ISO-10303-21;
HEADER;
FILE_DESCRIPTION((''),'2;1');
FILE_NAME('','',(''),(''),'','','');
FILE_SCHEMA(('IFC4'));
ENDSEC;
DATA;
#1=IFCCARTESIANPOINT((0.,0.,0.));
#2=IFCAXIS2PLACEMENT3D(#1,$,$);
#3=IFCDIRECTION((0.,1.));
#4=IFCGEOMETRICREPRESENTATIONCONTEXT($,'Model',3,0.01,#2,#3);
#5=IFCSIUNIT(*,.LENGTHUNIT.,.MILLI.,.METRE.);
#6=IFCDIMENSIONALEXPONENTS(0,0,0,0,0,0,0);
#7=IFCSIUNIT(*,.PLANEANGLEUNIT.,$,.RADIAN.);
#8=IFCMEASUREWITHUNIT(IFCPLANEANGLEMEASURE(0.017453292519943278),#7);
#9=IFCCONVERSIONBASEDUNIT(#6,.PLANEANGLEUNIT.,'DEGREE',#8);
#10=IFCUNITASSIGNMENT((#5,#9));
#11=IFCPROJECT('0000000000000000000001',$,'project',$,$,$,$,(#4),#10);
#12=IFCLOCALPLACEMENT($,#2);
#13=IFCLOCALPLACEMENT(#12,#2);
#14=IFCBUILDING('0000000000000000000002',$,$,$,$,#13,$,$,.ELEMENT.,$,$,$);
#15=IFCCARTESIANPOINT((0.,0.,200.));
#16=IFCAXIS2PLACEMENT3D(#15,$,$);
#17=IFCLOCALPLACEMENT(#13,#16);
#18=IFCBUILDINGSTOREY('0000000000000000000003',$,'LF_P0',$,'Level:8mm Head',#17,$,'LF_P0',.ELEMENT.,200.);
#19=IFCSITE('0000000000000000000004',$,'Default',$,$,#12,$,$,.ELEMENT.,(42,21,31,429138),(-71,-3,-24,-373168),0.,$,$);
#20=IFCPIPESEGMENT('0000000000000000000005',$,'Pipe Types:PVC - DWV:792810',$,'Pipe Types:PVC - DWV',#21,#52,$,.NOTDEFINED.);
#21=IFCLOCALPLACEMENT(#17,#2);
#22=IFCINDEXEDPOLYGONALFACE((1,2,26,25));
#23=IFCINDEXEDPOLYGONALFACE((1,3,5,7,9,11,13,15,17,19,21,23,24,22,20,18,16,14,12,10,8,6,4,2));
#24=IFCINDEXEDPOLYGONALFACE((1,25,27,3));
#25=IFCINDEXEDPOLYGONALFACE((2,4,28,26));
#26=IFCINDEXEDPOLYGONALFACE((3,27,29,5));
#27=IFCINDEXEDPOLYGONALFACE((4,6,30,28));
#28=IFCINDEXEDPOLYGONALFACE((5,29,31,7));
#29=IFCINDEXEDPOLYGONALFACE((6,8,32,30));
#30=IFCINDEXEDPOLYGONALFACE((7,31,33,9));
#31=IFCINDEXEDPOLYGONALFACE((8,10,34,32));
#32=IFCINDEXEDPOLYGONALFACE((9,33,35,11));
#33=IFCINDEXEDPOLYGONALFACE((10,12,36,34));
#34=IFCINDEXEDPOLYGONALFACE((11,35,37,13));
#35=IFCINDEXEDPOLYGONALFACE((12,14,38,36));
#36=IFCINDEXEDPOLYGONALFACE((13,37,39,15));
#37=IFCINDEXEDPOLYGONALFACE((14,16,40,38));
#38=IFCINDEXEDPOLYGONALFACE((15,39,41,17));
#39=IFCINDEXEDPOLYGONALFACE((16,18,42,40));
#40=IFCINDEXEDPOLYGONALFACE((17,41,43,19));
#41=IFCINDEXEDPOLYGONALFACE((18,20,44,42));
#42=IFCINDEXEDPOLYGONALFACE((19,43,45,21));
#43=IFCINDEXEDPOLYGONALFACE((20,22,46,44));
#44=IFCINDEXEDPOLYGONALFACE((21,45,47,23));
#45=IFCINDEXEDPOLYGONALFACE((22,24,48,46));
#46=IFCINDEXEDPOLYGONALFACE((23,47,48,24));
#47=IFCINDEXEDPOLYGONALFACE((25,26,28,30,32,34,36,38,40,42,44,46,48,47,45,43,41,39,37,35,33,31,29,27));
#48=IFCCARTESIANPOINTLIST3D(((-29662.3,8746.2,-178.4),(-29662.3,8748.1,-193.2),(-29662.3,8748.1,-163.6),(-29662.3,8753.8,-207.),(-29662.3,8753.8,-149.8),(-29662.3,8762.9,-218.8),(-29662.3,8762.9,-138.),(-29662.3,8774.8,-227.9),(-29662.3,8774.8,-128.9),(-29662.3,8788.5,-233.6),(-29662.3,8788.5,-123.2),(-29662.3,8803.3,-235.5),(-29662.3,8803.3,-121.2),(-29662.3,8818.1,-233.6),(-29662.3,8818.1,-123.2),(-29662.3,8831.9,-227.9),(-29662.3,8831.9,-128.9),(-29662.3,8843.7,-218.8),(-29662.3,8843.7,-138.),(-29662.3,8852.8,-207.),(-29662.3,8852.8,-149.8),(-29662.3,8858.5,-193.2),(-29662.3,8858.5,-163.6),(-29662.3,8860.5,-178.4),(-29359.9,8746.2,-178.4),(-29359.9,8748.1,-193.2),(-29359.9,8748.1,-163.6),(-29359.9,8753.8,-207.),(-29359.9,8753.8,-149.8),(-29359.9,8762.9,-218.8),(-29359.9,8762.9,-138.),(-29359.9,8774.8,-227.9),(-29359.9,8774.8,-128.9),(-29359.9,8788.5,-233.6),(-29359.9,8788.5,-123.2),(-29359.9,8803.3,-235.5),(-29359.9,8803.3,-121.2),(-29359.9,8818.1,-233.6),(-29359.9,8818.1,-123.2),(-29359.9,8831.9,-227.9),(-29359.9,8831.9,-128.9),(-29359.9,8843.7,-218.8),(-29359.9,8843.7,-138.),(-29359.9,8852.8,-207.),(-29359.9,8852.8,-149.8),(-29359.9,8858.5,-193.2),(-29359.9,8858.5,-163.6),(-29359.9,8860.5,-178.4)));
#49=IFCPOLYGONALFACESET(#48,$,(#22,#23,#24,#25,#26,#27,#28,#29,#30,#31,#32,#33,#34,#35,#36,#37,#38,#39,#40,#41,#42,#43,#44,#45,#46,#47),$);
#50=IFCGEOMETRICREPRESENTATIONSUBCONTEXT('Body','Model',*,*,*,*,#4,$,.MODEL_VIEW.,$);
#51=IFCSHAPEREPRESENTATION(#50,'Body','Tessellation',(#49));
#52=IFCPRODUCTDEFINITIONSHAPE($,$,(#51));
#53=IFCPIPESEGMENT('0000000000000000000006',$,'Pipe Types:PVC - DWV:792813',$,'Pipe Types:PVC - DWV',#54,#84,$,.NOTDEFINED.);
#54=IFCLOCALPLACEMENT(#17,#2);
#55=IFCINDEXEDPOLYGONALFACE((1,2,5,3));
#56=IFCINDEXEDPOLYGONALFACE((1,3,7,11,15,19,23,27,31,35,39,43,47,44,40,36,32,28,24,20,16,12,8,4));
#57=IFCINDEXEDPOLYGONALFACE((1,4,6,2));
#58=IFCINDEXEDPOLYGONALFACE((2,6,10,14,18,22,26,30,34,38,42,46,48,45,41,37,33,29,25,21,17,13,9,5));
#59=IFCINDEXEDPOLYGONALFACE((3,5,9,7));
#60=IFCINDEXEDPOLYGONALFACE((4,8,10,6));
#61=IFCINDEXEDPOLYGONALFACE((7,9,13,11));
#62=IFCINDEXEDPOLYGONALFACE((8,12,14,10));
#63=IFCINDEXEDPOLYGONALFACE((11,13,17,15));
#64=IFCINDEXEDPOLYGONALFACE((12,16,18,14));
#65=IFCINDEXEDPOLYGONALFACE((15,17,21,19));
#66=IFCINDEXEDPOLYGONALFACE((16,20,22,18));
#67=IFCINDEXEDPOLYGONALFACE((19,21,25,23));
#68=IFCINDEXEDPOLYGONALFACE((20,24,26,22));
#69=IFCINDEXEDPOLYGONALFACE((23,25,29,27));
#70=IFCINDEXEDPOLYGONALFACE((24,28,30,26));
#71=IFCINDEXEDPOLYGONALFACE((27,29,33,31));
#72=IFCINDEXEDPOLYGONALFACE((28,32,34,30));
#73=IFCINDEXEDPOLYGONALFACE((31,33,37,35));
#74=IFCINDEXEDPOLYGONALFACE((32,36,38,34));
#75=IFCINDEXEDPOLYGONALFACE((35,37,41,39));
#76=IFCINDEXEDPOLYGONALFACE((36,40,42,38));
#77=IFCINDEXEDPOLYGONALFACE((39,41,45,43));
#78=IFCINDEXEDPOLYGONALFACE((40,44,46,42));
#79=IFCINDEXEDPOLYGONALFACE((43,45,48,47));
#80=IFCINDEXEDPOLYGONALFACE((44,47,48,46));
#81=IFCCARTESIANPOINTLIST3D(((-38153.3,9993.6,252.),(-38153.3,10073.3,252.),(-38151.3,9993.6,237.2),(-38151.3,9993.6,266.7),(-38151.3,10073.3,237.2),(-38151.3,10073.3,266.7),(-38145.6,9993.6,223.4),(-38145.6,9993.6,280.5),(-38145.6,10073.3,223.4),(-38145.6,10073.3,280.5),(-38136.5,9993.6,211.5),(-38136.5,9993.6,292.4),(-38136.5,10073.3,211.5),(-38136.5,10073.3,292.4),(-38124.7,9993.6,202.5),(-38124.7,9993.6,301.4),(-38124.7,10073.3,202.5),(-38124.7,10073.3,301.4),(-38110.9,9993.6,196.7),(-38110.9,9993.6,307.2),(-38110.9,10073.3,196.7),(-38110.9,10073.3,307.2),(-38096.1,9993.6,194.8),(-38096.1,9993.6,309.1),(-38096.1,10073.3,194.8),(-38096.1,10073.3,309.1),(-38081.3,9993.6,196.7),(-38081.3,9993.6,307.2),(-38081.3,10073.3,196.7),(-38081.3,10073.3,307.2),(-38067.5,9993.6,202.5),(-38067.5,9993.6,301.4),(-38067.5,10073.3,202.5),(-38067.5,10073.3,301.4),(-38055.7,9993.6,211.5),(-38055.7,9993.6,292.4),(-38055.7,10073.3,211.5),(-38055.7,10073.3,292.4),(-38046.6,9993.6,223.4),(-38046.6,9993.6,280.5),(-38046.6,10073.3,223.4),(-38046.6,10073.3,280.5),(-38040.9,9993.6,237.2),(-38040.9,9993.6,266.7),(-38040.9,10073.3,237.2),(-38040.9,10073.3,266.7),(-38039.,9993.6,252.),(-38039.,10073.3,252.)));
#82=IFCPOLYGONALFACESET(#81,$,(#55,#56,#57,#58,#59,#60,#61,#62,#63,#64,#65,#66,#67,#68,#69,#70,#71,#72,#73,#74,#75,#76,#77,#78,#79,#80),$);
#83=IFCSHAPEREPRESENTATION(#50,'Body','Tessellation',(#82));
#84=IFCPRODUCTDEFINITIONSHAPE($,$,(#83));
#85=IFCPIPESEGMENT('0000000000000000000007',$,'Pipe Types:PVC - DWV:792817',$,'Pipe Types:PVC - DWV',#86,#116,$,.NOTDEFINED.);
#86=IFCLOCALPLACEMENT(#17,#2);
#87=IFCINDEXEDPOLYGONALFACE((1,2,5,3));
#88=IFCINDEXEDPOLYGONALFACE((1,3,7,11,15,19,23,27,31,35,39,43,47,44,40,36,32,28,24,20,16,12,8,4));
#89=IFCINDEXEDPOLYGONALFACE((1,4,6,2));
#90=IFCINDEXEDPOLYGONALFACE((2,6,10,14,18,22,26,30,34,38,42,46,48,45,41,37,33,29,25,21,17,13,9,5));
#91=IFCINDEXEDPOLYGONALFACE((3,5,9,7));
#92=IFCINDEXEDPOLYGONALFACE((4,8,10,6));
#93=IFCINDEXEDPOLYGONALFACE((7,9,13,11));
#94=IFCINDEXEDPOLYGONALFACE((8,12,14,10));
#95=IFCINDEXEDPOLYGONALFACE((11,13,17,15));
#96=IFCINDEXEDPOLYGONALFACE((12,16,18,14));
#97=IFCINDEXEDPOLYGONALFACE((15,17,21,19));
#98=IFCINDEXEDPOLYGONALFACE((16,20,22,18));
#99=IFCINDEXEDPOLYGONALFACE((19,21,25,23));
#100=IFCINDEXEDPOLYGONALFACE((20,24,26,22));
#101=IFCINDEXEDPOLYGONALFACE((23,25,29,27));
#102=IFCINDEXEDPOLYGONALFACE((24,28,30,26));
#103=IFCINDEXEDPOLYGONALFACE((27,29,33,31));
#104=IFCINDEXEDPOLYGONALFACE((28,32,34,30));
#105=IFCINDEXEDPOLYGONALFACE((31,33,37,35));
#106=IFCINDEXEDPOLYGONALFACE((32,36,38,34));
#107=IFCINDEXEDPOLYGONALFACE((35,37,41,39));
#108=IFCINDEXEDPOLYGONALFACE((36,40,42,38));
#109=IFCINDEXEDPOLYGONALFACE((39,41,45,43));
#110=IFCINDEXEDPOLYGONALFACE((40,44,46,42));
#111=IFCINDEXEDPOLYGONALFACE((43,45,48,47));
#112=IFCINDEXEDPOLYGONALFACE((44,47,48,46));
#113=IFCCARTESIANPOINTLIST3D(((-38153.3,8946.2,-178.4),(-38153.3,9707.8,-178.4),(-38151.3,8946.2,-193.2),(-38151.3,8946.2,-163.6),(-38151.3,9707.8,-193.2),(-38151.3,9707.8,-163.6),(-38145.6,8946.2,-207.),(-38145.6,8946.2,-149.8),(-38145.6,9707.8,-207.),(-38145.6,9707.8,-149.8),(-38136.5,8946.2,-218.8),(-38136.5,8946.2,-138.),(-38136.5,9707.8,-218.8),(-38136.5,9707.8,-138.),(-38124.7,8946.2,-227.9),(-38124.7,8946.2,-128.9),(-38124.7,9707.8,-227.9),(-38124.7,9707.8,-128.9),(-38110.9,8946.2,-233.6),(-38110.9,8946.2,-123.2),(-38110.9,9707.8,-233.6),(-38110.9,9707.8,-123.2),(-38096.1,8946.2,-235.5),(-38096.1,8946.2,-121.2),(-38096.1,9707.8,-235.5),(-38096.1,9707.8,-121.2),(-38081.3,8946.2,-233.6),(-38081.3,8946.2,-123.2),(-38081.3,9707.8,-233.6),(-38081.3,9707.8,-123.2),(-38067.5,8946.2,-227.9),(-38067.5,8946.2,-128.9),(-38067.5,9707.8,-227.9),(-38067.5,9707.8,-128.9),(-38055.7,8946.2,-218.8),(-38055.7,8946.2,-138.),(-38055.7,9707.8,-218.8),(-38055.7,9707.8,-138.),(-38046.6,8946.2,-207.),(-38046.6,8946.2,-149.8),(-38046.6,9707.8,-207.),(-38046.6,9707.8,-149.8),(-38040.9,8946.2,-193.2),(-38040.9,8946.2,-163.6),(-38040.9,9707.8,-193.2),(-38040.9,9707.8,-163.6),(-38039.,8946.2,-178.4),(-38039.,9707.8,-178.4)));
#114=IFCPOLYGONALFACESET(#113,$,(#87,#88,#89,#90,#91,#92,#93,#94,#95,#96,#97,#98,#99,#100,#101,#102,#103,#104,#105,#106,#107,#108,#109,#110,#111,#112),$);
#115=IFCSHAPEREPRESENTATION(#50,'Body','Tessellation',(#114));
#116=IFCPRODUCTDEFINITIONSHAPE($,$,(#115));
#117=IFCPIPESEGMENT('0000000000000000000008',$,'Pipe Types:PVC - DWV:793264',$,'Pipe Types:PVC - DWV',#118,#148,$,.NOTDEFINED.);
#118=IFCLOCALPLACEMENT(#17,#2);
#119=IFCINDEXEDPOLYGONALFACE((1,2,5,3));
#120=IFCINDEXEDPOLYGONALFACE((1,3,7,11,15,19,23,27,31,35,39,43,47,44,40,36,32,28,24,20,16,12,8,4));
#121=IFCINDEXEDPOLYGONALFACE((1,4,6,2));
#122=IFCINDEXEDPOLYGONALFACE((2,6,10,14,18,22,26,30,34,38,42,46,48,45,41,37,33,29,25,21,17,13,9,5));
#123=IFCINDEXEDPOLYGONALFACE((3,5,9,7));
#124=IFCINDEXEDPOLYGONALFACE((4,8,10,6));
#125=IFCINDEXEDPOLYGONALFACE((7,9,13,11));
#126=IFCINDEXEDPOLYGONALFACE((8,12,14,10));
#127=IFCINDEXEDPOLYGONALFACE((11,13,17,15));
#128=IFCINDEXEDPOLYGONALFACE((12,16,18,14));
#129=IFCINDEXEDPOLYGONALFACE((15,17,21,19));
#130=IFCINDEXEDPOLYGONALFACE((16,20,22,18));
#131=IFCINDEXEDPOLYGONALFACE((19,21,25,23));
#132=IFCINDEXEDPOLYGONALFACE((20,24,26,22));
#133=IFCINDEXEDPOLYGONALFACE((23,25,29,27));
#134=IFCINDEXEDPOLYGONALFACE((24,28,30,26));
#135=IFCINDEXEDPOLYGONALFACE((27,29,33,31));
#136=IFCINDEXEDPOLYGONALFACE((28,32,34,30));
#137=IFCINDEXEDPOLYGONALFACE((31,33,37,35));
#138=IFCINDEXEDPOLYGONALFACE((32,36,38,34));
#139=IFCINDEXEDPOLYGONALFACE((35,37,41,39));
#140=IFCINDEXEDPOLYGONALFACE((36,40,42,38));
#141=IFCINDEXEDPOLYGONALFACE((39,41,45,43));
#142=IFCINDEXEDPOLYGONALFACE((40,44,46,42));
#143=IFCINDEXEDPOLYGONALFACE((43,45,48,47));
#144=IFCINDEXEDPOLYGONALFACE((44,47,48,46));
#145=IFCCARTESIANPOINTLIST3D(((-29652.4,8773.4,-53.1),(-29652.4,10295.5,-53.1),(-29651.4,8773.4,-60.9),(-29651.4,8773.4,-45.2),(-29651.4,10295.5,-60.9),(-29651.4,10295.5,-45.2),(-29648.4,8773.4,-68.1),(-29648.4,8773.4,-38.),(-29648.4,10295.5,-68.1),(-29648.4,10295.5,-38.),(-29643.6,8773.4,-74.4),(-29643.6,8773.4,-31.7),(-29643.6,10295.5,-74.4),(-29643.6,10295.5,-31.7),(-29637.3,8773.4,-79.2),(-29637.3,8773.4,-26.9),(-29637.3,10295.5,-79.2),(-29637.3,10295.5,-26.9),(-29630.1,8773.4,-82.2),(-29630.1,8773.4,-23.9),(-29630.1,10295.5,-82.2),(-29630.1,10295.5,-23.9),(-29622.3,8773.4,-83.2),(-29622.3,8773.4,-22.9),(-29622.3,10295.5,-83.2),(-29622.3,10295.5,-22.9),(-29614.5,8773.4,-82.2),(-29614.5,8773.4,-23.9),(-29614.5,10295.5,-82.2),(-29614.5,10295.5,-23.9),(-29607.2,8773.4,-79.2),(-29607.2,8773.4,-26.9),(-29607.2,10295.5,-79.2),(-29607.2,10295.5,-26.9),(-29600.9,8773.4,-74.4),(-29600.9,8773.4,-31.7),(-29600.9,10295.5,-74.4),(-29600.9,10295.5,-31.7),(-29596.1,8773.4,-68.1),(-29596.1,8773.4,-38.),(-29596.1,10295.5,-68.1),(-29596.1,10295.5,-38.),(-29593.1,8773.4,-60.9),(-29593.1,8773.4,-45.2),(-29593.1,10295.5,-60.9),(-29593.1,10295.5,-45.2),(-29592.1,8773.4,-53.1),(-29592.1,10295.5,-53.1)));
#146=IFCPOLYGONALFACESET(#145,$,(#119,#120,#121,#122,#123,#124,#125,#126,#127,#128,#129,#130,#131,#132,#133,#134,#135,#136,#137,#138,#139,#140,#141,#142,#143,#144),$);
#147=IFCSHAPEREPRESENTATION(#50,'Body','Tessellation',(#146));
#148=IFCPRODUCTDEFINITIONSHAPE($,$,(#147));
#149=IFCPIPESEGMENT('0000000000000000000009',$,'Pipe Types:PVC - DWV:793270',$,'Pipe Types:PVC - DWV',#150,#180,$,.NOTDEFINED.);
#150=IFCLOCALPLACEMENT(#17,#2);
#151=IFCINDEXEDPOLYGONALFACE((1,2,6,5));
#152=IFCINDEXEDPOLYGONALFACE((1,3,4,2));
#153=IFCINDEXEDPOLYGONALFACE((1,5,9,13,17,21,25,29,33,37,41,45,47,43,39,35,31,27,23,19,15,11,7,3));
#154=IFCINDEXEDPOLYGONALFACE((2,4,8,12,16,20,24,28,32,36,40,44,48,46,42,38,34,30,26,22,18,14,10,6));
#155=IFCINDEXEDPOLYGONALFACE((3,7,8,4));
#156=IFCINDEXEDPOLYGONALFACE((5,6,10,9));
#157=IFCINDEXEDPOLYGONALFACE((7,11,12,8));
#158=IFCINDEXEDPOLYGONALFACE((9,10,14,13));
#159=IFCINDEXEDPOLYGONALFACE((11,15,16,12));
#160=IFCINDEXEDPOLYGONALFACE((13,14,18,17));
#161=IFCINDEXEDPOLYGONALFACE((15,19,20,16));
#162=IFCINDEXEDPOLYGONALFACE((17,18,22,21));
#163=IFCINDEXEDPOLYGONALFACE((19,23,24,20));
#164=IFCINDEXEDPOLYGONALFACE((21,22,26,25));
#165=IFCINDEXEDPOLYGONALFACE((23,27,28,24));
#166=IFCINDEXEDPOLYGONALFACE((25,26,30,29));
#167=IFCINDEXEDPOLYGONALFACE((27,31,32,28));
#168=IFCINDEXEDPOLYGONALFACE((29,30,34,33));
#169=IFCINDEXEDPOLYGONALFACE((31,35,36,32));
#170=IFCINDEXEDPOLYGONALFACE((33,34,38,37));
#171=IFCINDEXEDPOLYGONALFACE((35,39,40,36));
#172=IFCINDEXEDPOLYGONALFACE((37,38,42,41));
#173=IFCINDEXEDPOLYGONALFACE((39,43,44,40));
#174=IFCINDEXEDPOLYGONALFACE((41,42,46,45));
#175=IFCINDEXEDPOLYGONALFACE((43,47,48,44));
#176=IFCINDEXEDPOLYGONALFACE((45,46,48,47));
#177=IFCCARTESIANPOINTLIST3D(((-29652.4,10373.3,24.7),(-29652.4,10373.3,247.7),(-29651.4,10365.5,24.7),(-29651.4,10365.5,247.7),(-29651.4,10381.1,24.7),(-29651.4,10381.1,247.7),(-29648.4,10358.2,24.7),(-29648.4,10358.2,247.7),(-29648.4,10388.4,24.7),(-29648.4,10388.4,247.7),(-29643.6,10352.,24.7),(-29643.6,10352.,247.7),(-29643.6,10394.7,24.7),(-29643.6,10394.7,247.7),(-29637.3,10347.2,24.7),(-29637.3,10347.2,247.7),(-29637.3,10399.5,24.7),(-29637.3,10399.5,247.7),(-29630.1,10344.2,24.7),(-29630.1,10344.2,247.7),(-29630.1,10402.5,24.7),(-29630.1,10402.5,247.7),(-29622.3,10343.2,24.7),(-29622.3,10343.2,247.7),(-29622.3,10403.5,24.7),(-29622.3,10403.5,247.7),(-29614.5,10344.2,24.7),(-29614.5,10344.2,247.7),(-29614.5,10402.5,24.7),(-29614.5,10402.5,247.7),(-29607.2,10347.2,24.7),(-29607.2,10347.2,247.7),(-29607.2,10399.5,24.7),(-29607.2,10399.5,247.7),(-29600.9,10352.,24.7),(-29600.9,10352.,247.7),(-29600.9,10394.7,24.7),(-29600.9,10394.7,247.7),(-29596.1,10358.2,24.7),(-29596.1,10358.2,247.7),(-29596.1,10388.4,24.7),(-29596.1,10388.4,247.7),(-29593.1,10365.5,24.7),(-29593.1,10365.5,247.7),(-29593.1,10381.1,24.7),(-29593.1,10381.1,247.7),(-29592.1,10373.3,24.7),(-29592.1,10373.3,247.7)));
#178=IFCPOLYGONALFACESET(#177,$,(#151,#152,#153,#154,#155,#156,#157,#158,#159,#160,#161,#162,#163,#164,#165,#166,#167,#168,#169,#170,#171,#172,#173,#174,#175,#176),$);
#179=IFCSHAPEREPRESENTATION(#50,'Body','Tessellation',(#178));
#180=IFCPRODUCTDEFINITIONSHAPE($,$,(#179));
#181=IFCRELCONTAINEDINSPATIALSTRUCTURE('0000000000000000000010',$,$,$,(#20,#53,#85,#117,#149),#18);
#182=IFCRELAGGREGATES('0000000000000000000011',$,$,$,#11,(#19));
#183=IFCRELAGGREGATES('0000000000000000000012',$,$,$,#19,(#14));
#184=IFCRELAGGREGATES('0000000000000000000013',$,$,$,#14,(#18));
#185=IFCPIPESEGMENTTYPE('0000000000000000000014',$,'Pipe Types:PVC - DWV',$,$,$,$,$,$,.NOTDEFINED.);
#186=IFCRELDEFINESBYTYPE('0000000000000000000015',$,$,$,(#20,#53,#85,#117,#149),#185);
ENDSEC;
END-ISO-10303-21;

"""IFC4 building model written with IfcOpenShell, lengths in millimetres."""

from ifc_helpers import new_model, entity, si_unit, converted_unit, direction, frame, origin, place, context, subcontext, project, spatial, arc, indexed_curve, outline, extrude, type_object, element, save


model = new_model("IFC4")

# Units and contexts
model_context = context("Model", 3, precision=0.01, world=origin(), true_north=direction((0.0, 1.0)))
body_context = subcontext(model_context, "Body", "Model", "MODEL_VIEW")
ifc_project = project(units=[si_unit("LENGTHUNIT", "METRE", prefix="MILLI"), converted_unit("PLANEANGLEUNIT", "DEGREE", entity("IfcPlaneAngleMeasure", 0.017453292519943278), si_unit("PLANEANGLEUNIT", "RADIAN"), dimensions=[0, 0, 0, 0, 0, 0, 0])], contexts=[model_context])

# Site, building, storey
site_placement = place(None, origin())
site = spatial("IfcSite", under=ifc_project, at=site_placement, Name="Default", CompositionType="ELEMENT", RefLatitude=(42, 21, 31, 429138), RefLongitude=(-71, -3, -24, -373168), RefElevation=0.0)
building_placement = place(site_placement, origin())
building = spatial("IfcBuilding", under=site, at=building_placement, CompositionType="ELEMENT")
storey_placement = place(building_placement, frame((0.0, 0.0, 200.0)))
storey = spatial("IfcBuildingStorey", under=building, at=storey_placement, Name="LF_P0", ObjectType="Level:8mm Head", LongName="LF_P0", CompositionType="ELEMENT", Elevation=200.0)

# Pipe segments
pipe_segment_type_1 = type_object("IfcPipeSegmentType", Name="Pipe Types:PVC - DWV", PredefinedType="NOTDEFINED")
pipe_segment_1_placement = place(storey_placement, origin())
element("IfcPipeSegment", 1, at=pipe_segment_1_placement, inside=storey, type_object=pipe_segment_type_1, Name="Pipe Types:PVC - DWV:792810", ObjectType="Pipe Types:PVC - DWV", PredefinedType="NOTDEFINED", context=body_context, shape_type="SweptSolid", body=[
    extrude(outline(indexed_curve([(57.2, 0.0), (40.4, 40.4), (0.0, 57.2), (-40.4, 40.4), (-57.1, 0.0), (-40.4, -40.4), (0.0, -57.1), (40.4, -40.4)], segments=[arc(1, 2, 3), arc(3, 4, 5), arc(5, 6, 7), arc(7, 8, 1)], self_intersect=False)), frame((-29662.3, 8803.3, -178.4), z_axis=(1.0, 0.0, 0.0), x_axis=(0.0, 1.0, 0.0)), (0.0, 0.0, 1.0), 302.3),
])
pipe_segment_2_placement = place(storey_placement, origin())
element("IfcPipeSegment", 2, at=pipe_segment_2_placement, inside=storey, type_object=pipe_segment_type_1, Name="Pipe Types:PVC - DWV:792813", ObjectType="Pipe Types:PVC - DWV", PredefinedType="NOTDEFINED", context=body_context, shape_type="SweptSolid", body=[
    extrude(outline(indexed_curve([(57.2, 0.0), (40.4, 40.4), (0.0, 57.2), (-40.4, 40.4), (-57.2, 0.0), (-40.4, -40.4), (0.0, -57.2), (40.4, -40.4)], segments=[arc(1, 2, 3), arc(3, 4, 5), arc(5, 6, 7), arc(7, 8, 1)], self_intersect=False)), frame((-38096.1, 9993.6, 252.0), z_axis=(0.0, 1.0, 0.0), x_axis=(-1.0, 0.0, 0.0)), (0.0, 0.0, 1.0), 79.8),
])
pipe_segment_3_placement = place(storey_placement, origin())
element("IfcPipeSegment", 3, at=pipe_segment_3_placement, inside=storey, type_object=pipe_segment_type_1, Name="Pipe Types:PVC - DWV:792817", ObjectType="Pipe Types:PVC - DWV", PredefinedType="NOTDEFINED", context=body_context, shape_type="SweptSolid", body=[
    extrude(outline(indexed_curve([(57.2, 0.0), (40.4, 40.4), (0.0, 57.1), (-40.4, 40.4), (-57.2, 0.0), (-40.4, -40.4), (0.0, -57.2), (40.4, -40.4)], segments=[arc(1, 2, 3), arc(3, 4, 5), arc(5, 6, 7), arc(7, 8, 1)], self_intersect=False)), frame((-38096.1, 8946.2, -178.4), z_axis=(0.0, 1.0, 0.0), x_axis=(-1.0, 0.0, 0.0)), (0.0, 0.0, 1.0), 761.6),
])
pipe_segment_4_placement = place(storey_placement, origin())
element("IfcPipeSegment", 4, at=pipe_segment_4_placement, inside=storey, type_object=pipe_segment_type_1, Name="Pipe Types:PVC - DWV:793264", ObjectType="Pipe Types:PVC - DWV", PredefinedType="NOTDEFINED", context=body_context, shape_type="SweptSolid", body=[
    extrude(outline(indexed_curve([(30.2, 0.0), (21.3, 21.3), (0.0, 30.2), (-21.3, 21.3), (-30.2, 0.0), (-21.3, -21.3), (0.0, -30.2), (21.3, -21.3)], segments=[arc(1, 2, 3), arc(3, 4, 5), arc(5, 6, 7), arc(7, 8, 1)], self_intersect=False)), frame((-29622.3, 8773.4, -53.1), z_axis=(0.0, 1.0, 0.0), x_axis=(1.0, 0.0, 0.0)), (0.0, 0.0, 1.0), 1522.1),
])
pipe_segment_5_placement = place(storey_placement, origin())
element("IfcPipeSegment", 5, at=pipe_segment_5_placement, inside=storey, type_object=pipe_segment_type_1, Name="Pipe Types:PVC - DWV:793270", ObjectType="Pipe Types:PVC - DWV", PredefinedType="NOTDEFINED", context=body_context, shape_type="SweptSolid", body=[
    extrude(outline(indexed_curve([(30.2, 0.0), (21.3, 21.3), (0.0, 30.2), (-21.3, 21.3), (-30.2, 0.0), (-21.3, -21.3), (0.0, -30.2), (21.3, -21.3)], segments=[arc(1, 2, 3), arc(3, 4, 5), arc(5, 6, 7), arc(7, 8, 1)], self_intersect=False)), frame((-29622.3, 10373.3, 24.7), z_axis=(0.0, 0.0, 1.0), x_axis=(-1.0, 0.0, 0.0)), (0.0, 0.0, 1.0), 223.0),
])

save(model, "model.ifc")
